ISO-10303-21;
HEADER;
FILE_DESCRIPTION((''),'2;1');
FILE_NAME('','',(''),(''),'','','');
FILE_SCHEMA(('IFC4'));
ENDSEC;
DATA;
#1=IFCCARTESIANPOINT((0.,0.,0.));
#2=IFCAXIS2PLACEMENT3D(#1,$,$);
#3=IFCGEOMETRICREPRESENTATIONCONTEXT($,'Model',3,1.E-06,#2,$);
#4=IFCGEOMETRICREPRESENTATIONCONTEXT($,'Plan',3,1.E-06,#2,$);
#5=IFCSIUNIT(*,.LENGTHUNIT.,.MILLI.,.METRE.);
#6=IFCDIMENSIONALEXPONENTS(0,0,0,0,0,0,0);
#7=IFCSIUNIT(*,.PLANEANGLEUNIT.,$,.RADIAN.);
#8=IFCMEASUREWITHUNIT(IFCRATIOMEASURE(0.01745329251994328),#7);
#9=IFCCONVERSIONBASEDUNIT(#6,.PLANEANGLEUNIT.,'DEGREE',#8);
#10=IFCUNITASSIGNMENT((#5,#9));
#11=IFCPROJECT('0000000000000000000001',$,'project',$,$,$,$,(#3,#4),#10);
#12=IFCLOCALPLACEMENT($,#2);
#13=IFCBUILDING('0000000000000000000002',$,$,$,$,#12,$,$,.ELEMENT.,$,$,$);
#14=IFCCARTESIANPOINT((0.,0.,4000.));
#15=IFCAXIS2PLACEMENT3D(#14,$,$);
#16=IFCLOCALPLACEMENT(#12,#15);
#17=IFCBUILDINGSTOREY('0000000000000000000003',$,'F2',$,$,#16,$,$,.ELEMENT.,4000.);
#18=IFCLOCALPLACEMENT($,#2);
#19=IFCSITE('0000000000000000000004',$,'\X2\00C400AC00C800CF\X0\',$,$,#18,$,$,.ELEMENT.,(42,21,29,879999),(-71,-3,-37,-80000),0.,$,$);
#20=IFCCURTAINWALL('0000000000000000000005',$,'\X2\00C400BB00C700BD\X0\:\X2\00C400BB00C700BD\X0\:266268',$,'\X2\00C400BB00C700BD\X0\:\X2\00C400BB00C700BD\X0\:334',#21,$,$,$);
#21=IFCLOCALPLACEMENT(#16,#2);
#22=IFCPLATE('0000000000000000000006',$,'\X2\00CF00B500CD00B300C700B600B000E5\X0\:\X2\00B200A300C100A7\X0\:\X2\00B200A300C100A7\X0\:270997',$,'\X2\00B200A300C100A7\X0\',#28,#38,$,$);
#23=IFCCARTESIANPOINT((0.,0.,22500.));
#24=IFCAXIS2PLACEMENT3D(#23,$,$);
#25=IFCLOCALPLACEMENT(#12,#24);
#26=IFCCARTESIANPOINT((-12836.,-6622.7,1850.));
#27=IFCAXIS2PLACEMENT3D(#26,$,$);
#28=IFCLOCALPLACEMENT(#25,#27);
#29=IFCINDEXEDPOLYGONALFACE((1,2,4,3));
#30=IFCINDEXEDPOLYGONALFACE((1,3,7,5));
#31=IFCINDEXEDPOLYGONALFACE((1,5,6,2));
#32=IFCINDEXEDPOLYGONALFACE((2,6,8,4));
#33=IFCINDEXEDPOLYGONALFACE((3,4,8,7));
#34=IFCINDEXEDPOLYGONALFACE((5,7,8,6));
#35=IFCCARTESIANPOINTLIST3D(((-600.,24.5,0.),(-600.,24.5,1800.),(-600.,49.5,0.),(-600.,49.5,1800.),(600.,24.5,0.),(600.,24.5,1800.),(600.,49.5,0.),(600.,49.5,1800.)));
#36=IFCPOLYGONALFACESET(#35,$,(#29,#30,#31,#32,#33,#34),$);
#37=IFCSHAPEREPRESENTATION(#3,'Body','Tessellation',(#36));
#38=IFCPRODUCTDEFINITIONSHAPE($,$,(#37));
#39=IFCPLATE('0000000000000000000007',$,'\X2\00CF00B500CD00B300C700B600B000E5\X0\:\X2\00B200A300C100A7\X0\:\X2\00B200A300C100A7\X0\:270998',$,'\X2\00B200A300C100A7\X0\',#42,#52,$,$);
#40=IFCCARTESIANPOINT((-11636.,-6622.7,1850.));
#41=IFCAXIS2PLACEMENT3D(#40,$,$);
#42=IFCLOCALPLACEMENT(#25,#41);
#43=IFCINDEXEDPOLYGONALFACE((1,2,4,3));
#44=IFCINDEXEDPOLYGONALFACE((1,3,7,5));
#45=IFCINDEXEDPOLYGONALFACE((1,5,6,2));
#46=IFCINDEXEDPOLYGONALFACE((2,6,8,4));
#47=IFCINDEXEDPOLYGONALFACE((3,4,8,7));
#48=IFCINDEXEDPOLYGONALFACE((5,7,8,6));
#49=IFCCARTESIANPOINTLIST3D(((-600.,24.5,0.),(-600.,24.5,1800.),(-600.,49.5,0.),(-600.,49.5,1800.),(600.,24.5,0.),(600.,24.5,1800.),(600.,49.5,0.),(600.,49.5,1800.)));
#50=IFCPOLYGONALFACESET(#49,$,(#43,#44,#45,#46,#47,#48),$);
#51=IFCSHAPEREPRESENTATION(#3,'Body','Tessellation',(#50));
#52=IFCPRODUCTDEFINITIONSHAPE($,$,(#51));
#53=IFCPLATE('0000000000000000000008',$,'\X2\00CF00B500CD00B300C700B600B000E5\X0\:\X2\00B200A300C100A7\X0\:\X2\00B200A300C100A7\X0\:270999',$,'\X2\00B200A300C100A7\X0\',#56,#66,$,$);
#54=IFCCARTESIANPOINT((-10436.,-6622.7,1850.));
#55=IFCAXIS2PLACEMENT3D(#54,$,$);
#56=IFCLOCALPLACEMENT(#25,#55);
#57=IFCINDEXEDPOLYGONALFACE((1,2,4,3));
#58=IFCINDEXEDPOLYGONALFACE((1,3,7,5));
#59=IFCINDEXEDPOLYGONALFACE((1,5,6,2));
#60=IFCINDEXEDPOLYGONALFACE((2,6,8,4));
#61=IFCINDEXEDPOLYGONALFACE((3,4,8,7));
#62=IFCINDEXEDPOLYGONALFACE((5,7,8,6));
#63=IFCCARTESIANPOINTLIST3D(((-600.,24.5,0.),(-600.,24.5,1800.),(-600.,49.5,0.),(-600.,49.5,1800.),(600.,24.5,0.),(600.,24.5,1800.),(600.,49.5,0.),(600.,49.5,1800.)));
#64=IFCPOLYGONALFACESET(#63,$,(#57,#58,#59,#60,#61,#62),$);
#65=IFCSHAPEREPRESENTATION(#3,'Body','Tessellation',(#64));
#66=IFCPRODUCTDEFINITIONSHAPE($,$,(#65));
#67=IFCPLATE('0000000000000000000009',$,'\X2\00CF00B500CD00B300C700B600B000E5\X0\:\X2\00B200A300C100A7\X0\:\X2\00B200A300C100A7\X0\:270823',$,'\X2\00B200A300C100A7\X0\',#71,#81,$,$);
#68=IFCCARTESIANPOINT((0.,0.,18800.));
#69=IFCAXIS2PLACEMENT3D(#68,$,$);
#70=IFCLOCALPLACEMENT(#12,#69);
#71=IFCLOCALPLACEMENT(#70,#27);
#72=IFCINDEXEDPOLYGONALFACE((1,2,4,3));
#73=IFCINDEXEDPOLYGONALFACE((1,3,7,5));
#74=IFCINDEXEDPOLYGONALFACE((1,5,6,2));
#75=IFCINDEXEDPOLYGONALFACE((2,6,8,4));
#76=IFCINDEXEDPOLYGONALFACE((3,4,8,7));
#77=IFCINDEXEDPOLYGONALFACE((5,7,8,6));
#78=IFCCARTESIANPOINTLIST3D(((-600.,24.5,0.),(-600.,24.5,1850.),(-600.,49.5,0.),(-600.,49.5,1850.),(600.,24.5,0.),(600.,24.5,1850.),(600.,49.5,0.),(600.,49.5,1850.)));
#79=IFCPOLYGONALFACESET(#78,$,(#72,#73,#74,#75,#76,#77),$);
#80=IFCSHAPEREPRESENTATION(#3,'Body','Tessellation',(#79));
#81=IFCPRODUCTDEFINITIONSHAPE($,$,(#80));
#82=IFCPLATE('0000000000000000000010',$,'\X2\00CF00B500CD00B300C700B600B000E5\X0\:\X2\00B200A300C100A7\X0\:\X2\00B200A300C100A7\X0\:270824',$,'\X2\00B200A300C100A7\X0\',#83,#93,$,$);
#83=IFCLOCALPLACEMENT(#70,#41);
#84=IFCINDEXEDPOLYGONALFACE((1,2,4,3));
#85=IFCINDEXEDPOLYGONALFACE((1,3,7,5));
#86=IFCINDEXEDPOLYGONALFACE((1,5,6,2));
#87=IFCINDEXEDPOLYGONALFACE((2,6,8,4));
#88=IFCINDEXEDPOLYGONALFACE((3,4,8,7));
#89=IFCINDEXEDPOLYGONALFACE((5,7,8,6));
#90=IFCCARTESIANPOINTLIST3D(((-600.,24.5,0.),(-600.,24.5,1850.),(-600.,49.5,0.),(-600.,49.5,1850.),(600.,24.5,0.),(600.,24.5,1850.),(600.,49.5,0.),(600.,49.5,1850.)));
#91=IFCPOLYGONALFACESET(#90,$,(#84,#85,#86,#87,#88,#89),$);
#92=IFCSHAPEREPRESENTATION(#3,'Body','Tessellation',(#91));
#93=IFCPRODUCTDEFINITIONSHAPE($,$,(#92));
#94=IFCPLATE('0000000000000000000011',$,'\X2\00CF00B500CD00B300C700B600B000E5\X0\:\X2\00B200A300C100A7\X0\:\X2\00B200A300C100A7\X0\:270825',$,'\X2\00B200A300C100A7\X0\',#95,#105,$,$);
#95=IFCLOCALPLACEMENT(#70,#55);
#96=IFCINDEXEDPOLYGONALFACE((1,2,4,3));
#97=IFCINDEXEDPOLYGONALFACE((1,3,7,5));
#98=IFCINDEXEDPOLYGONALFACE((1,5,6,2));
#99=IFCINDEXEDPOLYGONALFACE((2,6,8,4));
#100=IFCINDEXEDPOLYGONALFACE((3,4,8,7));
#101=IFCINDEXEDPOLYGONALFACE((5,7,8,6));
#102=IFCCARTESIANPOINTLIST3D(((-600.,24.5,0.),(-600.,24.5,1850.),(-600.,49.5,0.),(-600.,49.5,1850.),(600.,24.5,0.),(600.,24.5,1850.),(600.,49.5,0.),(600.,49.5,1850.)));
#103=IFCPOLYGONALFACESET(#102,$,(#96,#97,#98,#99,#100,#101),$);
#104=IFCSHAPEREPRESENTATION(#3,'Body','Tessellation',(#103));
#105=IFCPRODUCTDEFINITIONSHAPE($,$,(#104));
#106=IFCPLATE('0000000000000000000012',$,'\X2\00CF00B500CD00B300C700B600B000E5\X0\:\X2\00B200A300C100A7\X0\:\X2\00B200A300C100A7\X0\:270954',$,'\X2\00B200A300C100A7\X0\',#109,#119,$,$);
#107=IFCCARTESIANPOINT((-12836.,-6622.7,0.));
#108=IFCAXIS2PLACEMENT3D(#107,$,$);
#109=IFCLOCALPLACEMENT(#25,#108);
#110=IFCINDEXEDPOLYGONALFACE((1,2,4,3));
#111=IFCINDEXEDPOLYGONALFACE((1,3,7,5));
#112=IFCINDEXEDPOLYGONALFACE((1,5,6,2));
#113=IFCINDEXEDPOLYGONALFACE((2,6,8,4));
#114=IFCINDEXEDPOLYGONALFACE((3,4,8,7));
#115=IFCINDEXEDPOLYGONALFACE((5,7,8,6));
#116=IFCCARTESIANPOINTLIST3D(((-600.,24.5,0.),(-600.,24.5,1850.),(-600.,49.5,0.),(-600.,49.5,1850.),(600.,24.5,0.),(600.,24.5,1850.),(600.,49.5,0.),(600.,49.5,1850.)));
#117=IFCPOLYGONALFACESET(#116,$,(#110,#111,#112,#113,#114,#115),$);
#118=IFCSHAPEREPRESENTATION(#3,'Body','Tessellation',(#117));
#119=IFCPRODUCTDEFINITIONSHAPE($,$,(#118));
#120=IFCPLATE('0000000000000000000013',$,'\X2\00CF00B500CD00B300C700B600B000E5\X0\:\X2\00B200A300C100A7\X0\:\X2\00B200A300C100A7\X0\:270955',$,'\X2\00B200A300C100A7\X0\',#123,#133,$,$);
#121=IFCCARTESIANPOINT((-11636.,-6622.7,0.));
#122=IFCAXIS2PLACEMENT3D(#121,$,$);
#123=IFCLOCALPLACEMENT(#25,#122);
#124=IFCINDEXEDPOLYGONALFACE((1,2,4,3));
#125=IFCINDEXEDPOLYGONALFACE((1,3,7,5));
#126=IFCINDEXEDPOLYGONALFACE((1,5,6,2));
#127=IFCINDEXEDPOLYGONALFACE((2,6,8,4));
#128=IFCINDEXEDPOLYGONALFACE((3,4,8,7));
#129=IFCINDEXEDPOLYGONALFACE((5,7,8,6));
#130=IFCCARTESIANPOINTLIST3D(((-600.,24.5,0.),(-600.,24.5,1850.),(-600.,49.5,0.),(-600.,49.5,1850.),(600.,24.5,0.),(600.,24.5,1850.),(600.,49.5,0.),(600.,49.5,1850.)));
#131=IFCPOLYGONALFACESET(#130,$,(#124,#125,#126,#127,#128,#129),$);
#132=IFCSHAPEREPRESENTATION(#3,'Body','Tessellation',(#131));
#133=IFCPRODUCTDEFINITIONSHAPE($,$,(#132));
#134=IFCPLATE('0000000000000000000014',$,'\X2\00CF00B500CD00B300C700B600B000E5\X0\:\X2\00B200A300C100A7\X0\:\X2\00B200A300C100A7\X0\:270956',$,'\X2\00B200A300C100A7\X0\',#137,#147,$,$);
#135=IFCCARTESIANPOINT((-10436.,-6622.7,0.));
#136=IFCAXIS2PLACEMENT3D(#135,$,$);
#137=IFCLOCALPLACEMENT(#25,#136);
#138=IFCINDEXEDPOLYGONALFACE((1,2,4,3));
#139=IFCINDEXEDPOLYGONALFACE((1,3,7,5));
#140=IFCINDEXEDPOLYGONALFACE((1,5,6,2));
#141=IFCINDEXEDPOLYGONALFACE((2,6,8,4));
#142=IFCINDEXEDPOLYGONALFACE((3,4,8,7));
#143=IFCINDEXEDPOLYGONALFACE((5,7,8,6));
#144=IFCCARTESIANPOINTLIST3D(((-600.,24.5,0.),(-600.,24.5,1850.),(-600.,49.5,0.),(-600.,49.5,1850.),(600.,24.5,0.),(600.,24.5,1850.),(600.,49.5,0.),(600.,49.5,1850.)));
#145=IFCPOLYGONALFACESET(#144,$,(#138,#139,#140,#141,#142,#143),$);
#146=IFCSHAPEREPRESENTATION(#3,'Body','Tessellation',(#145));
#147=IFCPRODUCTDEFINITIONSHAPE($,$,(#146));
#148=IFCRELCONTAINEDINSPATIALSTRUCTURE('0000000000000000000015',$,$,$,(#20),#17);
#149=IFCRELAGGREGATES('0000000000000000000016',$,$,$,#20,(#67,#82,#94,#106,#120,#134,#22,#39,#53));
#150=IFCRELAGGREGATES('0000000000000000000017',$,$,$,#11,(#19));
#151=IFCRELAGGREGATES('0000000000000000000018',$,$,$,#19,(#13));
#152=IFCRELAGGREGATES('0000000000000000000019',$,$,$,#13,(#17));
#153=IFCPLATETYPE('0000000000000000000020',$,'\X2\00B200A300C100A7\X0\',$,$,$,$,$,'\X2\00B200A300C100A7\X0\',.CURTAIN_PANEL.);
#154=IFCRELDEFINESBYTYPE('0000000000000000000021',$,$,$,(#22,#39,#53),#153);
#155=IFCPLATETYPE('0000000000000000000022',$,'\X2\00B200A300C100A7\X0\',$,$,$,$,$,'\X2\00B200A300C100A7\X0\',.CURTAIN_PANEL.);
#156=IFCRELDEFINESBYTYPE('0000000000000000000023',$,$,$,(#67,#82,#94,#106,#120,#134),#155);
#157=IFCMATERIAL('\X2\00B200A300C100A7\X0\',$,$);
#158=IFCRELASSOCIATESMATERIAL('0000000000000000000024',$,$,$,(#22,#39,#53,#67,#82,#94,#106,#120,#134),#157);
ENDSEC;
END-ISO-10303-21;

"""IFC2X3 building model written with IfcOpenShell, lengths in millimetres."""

from ifc_helpers import new_model, entity, si_unit, converted_unit, frame, origin, origin_2d_with_axis, place, context, project, spatial, rectangle, extrude, source, transform, mapped, material, type_object, type_shapes, element, aggregate, save


model = new_model("IFC2X3")

# Units and contexts
model_context = context("Model", 3, precision=1e-06, world=origin())
plan_context = context("Plan", 3, precision=1e-06, world=origin())
ifc_project = project(units=[si_unit("LENGTHUNIT", "METRE", prefix="MILLI"), converted_unit("PLANEANGLEUNIT", "DEGREE", entity("IfcRatioMeasure", 0.01745329251994328), si_unit("PLANEANGLEUNIT", "RADIAN"), dimensions=[0, 0, 0, 0, 0, 0, 0])], contexts=[model_context, plan_context])

# Site, building, storey
site_placement = place(None, origin())
site = spatial("IfcSite", under=ifc_project, at=site_placement, Name="Ä¬ÈÏ", CompositionType="ELEMENT", RefLatitude=(42, 21, 29, 879999), RefLongitude=(-71, -3, -37, -80000), RefElevation=0.0)
building_placement = place(None, origin())
building = spatial("IfcBuilding", under=site, at=building_placement, CompositionType="ELEMENT")
storey_placement = place(building_placement, frame((0.0, 0.0, 4000.0)))
storey = spatial("IfcBuildingStorey", under=building, at=storey_placement, Name="F2", CompositionType="ELEMENT", Elevation=4000.0)

# Curtain wall, plates
curtain_wall_placement = place(storey_placement, origin())
curtain_wall = element("IfcCurtainWall", 1, at=curtain_wall_placement, inside=storey, Name="Ä»Ç½:Ä»Ç½:266268", ObjectType="Ä»Ç½:Ä»Ç½:334")
placement_1 = place(building_placement, frame((0.0, 0.0, 18800.0)))
placement_2 = place(building_placement, frame((0.0, 0.0, 22500.0)))
ifc_material_1 = material(Name="²£Á§")
plate_type_1 = type_object("IfcPlateType", Name="²£Á§", ElementType="²£Á§", PredefinedType="CURTAIN_PANEL")
shared_shape_1 = source(origin(), model_context, "Body", "SweptSolid", [
    extrude(rectangle(XDim=25.0, YDim=1200.0, at=origin_2d_with_axis()), frame((0.0, 37.0, 0.0), z_axis=(0.0, 0.0, 1.0), x_axis=(0.0, 1.0, 0.0)), (0.0, 0.0, 1.0), 1800.0),
])
type_shapes(plate_type_1, [shared_shape_1])
plate_1_placement = place(placement_2, frame((-12836.0, -6622.7, 1850.0)))
plate_1 = element("IfcPlate", 2, at=plate_1_placement, type_object=plate_type_1, material=ifc_material_1, Name="ÏµÍ³Ç¶°å:²£Á§:²£Á§:270997", ObjectType="²£Á§", context=model_context, shape_type="MappedRepresentation", body=[
    mapped(shared_shape_1, transform((0.0, 0.0, 0.0), scale=1.0)),
])
plate_2_placement = place(placement_2, frame((-11636.0, -6622.7, 1850.0)))
plate_2 = element("IfcPlate", 3, at=plate_2_placement, type_object=plate_type_1, material=ifc_material_1, Name="ÏµÍ³Ç¶°å:²£Á§:²£Á§:270998", ObjectType="²£Á§", context=model_context, shape_type="MappedRepresentation", body=[
    mapped(shared_shape_1, transform((0.0, 0.0, 0.0), scale=1.0)),
])
plate_3_placement = place(placement_2, frame((-10436.0, -6622.7, 1850.0)))
plate_3 = element("IfcPlate", 4, at=plate_3_placement, type_object=plate_type_1, material=ifc_material_1, Name="ÏµÍ³Ç¶°å:²£Á§:²£Á§:270999", ObjectType="²£Á§", context=model_context, shape_type="MappedRepresentation", body=[
    mapped(shared_shape_1, transform((0.0, 0.0, 0.0), scale=1.0)),
])
plate_type_2 = type_object("IfcPlateType", Name="²£Á§", ElementType="²£Á§", PredefinedType="CURTAIN_PANEL")
shared_shape_2 = source(origin(), model_context, "Body", "SweptSolid", [
    extrude(rectangle(XDim=25.0, YDim=1200.0, at=origin_2d_with_axis()), frame((0.0, 37.0, 0.0), z_axis=(0.0, 0.0, 1.0), x_axis=(0.0, 1.0, 0.0)), (0.0, 0.0, 1.0), 1850.0),
])
type_shapes(plate_type_2, [shared_shape_2])
plate_4_placement = place(placement_1, frame((-12836.0, -6622.7, 1850.0)))
plate_4 = element("IfcPlate", 5, at=plate_4_placement, type_object=plate_type_2, material=ifc_material_1, Name="ÏµÍ³Ç¶°å:²£Á§:²£Á§:270823", ObjectType="²£Á§", context=model_context, shape_type="MappedRepresentation", body=[
    mapped(shared_shape_2, transform((0.0, 0.0, 0.0), scale=1.0)),
])
plate_5_placement = place(placement_1, frame((-11636.0, -6622.7, 1850.0)))
plate_5 = element("IfcPlate", 6, at=plate_5_placement, type_object=plate_type_2, material=ifc_material_1, Name="ÏµÍ³Ç¶°å:²£Á§:²£Á§:270824", ObjectType="²£Á§", context=model_context, shape_type="MappedRepresentation", body=[
    mapped(shared_shape_2, transform((0.0, 0.0, 0.0), scale=1.0)),
])
plate_6_placement = place(placement_1, frame((-10436.0, -6622.7, 1850.0)))
plate_6 = element("IfcPlate", 7, at=plate_6_placement, type_object=plate_type_2, material=ifc_material_1, Name="ÏµÍ³Ç¶°å:²£Á§:²£Á§:270825", ObjectType="²£Á§", context=model_context, shape_type="MappedRepresentation", body=[
    mapped(shared_shape_2, transform((0.0, 0.0, 0.0), scale=1.0)),
])
plate_7_placement = place(placement_2, frame((-12836.0, -6622.7, 0.0)))
plate_7 = element("IfcPlate", 8, at=plate_7_placement, type_object=plate_type_2, material=ifc_material_1, Name="ÏµÍ³Ç¶°å:²£Á§:²£Á§:270954", ObjectType="²£Á§", context=model_context, shape_type="MappedRepresentation", body=[
    mapped(shared_shape_2, transform((0.0, 0.0, 0.0), scale=1.0)),
])
plate_8_placement = place(placement_2, frame((-11636.0, -6622.7, 0.0)))
plate_8 = element("IfcPlate", 9, at=plate_8_placement, type_object=plate_type_2, material=ifc_material_1, Name="ÏµÍ³Ç¶°å:²£Á§:²£Á§:270955", ObjectType="²£Á§", context=model_context, shape_type="MappedRepresentation", body=[
    mapped(shared_shape_2, transform((0.0, 0.0, 0.0), scale=1.0)),
])
plate_9_placement = place(placement_2, frame((-10436.0, -6622.7, 0.0)))
plate_9 = element("IfcPlate", 10, at=plate_9_placement, type_object=plate_type_2, material=ifc_material_1, Name="ÏµÍ³Ç¶°å:²£Á§:²£Á§:270956", ObjectType="²£Á§", context=model_context, shape_type="MappedRepresentation", body=[
    mapped(shared_shape_2, transform((0.0, 0.0, 0.0), scale=1.0)),
])
aggregate(curtain_wall, [plate_4, plate_5, plate_6, plate_7, plate_8, plate_9, plate_1, plate_2, plate_3])

save(model, "model.ifc")
